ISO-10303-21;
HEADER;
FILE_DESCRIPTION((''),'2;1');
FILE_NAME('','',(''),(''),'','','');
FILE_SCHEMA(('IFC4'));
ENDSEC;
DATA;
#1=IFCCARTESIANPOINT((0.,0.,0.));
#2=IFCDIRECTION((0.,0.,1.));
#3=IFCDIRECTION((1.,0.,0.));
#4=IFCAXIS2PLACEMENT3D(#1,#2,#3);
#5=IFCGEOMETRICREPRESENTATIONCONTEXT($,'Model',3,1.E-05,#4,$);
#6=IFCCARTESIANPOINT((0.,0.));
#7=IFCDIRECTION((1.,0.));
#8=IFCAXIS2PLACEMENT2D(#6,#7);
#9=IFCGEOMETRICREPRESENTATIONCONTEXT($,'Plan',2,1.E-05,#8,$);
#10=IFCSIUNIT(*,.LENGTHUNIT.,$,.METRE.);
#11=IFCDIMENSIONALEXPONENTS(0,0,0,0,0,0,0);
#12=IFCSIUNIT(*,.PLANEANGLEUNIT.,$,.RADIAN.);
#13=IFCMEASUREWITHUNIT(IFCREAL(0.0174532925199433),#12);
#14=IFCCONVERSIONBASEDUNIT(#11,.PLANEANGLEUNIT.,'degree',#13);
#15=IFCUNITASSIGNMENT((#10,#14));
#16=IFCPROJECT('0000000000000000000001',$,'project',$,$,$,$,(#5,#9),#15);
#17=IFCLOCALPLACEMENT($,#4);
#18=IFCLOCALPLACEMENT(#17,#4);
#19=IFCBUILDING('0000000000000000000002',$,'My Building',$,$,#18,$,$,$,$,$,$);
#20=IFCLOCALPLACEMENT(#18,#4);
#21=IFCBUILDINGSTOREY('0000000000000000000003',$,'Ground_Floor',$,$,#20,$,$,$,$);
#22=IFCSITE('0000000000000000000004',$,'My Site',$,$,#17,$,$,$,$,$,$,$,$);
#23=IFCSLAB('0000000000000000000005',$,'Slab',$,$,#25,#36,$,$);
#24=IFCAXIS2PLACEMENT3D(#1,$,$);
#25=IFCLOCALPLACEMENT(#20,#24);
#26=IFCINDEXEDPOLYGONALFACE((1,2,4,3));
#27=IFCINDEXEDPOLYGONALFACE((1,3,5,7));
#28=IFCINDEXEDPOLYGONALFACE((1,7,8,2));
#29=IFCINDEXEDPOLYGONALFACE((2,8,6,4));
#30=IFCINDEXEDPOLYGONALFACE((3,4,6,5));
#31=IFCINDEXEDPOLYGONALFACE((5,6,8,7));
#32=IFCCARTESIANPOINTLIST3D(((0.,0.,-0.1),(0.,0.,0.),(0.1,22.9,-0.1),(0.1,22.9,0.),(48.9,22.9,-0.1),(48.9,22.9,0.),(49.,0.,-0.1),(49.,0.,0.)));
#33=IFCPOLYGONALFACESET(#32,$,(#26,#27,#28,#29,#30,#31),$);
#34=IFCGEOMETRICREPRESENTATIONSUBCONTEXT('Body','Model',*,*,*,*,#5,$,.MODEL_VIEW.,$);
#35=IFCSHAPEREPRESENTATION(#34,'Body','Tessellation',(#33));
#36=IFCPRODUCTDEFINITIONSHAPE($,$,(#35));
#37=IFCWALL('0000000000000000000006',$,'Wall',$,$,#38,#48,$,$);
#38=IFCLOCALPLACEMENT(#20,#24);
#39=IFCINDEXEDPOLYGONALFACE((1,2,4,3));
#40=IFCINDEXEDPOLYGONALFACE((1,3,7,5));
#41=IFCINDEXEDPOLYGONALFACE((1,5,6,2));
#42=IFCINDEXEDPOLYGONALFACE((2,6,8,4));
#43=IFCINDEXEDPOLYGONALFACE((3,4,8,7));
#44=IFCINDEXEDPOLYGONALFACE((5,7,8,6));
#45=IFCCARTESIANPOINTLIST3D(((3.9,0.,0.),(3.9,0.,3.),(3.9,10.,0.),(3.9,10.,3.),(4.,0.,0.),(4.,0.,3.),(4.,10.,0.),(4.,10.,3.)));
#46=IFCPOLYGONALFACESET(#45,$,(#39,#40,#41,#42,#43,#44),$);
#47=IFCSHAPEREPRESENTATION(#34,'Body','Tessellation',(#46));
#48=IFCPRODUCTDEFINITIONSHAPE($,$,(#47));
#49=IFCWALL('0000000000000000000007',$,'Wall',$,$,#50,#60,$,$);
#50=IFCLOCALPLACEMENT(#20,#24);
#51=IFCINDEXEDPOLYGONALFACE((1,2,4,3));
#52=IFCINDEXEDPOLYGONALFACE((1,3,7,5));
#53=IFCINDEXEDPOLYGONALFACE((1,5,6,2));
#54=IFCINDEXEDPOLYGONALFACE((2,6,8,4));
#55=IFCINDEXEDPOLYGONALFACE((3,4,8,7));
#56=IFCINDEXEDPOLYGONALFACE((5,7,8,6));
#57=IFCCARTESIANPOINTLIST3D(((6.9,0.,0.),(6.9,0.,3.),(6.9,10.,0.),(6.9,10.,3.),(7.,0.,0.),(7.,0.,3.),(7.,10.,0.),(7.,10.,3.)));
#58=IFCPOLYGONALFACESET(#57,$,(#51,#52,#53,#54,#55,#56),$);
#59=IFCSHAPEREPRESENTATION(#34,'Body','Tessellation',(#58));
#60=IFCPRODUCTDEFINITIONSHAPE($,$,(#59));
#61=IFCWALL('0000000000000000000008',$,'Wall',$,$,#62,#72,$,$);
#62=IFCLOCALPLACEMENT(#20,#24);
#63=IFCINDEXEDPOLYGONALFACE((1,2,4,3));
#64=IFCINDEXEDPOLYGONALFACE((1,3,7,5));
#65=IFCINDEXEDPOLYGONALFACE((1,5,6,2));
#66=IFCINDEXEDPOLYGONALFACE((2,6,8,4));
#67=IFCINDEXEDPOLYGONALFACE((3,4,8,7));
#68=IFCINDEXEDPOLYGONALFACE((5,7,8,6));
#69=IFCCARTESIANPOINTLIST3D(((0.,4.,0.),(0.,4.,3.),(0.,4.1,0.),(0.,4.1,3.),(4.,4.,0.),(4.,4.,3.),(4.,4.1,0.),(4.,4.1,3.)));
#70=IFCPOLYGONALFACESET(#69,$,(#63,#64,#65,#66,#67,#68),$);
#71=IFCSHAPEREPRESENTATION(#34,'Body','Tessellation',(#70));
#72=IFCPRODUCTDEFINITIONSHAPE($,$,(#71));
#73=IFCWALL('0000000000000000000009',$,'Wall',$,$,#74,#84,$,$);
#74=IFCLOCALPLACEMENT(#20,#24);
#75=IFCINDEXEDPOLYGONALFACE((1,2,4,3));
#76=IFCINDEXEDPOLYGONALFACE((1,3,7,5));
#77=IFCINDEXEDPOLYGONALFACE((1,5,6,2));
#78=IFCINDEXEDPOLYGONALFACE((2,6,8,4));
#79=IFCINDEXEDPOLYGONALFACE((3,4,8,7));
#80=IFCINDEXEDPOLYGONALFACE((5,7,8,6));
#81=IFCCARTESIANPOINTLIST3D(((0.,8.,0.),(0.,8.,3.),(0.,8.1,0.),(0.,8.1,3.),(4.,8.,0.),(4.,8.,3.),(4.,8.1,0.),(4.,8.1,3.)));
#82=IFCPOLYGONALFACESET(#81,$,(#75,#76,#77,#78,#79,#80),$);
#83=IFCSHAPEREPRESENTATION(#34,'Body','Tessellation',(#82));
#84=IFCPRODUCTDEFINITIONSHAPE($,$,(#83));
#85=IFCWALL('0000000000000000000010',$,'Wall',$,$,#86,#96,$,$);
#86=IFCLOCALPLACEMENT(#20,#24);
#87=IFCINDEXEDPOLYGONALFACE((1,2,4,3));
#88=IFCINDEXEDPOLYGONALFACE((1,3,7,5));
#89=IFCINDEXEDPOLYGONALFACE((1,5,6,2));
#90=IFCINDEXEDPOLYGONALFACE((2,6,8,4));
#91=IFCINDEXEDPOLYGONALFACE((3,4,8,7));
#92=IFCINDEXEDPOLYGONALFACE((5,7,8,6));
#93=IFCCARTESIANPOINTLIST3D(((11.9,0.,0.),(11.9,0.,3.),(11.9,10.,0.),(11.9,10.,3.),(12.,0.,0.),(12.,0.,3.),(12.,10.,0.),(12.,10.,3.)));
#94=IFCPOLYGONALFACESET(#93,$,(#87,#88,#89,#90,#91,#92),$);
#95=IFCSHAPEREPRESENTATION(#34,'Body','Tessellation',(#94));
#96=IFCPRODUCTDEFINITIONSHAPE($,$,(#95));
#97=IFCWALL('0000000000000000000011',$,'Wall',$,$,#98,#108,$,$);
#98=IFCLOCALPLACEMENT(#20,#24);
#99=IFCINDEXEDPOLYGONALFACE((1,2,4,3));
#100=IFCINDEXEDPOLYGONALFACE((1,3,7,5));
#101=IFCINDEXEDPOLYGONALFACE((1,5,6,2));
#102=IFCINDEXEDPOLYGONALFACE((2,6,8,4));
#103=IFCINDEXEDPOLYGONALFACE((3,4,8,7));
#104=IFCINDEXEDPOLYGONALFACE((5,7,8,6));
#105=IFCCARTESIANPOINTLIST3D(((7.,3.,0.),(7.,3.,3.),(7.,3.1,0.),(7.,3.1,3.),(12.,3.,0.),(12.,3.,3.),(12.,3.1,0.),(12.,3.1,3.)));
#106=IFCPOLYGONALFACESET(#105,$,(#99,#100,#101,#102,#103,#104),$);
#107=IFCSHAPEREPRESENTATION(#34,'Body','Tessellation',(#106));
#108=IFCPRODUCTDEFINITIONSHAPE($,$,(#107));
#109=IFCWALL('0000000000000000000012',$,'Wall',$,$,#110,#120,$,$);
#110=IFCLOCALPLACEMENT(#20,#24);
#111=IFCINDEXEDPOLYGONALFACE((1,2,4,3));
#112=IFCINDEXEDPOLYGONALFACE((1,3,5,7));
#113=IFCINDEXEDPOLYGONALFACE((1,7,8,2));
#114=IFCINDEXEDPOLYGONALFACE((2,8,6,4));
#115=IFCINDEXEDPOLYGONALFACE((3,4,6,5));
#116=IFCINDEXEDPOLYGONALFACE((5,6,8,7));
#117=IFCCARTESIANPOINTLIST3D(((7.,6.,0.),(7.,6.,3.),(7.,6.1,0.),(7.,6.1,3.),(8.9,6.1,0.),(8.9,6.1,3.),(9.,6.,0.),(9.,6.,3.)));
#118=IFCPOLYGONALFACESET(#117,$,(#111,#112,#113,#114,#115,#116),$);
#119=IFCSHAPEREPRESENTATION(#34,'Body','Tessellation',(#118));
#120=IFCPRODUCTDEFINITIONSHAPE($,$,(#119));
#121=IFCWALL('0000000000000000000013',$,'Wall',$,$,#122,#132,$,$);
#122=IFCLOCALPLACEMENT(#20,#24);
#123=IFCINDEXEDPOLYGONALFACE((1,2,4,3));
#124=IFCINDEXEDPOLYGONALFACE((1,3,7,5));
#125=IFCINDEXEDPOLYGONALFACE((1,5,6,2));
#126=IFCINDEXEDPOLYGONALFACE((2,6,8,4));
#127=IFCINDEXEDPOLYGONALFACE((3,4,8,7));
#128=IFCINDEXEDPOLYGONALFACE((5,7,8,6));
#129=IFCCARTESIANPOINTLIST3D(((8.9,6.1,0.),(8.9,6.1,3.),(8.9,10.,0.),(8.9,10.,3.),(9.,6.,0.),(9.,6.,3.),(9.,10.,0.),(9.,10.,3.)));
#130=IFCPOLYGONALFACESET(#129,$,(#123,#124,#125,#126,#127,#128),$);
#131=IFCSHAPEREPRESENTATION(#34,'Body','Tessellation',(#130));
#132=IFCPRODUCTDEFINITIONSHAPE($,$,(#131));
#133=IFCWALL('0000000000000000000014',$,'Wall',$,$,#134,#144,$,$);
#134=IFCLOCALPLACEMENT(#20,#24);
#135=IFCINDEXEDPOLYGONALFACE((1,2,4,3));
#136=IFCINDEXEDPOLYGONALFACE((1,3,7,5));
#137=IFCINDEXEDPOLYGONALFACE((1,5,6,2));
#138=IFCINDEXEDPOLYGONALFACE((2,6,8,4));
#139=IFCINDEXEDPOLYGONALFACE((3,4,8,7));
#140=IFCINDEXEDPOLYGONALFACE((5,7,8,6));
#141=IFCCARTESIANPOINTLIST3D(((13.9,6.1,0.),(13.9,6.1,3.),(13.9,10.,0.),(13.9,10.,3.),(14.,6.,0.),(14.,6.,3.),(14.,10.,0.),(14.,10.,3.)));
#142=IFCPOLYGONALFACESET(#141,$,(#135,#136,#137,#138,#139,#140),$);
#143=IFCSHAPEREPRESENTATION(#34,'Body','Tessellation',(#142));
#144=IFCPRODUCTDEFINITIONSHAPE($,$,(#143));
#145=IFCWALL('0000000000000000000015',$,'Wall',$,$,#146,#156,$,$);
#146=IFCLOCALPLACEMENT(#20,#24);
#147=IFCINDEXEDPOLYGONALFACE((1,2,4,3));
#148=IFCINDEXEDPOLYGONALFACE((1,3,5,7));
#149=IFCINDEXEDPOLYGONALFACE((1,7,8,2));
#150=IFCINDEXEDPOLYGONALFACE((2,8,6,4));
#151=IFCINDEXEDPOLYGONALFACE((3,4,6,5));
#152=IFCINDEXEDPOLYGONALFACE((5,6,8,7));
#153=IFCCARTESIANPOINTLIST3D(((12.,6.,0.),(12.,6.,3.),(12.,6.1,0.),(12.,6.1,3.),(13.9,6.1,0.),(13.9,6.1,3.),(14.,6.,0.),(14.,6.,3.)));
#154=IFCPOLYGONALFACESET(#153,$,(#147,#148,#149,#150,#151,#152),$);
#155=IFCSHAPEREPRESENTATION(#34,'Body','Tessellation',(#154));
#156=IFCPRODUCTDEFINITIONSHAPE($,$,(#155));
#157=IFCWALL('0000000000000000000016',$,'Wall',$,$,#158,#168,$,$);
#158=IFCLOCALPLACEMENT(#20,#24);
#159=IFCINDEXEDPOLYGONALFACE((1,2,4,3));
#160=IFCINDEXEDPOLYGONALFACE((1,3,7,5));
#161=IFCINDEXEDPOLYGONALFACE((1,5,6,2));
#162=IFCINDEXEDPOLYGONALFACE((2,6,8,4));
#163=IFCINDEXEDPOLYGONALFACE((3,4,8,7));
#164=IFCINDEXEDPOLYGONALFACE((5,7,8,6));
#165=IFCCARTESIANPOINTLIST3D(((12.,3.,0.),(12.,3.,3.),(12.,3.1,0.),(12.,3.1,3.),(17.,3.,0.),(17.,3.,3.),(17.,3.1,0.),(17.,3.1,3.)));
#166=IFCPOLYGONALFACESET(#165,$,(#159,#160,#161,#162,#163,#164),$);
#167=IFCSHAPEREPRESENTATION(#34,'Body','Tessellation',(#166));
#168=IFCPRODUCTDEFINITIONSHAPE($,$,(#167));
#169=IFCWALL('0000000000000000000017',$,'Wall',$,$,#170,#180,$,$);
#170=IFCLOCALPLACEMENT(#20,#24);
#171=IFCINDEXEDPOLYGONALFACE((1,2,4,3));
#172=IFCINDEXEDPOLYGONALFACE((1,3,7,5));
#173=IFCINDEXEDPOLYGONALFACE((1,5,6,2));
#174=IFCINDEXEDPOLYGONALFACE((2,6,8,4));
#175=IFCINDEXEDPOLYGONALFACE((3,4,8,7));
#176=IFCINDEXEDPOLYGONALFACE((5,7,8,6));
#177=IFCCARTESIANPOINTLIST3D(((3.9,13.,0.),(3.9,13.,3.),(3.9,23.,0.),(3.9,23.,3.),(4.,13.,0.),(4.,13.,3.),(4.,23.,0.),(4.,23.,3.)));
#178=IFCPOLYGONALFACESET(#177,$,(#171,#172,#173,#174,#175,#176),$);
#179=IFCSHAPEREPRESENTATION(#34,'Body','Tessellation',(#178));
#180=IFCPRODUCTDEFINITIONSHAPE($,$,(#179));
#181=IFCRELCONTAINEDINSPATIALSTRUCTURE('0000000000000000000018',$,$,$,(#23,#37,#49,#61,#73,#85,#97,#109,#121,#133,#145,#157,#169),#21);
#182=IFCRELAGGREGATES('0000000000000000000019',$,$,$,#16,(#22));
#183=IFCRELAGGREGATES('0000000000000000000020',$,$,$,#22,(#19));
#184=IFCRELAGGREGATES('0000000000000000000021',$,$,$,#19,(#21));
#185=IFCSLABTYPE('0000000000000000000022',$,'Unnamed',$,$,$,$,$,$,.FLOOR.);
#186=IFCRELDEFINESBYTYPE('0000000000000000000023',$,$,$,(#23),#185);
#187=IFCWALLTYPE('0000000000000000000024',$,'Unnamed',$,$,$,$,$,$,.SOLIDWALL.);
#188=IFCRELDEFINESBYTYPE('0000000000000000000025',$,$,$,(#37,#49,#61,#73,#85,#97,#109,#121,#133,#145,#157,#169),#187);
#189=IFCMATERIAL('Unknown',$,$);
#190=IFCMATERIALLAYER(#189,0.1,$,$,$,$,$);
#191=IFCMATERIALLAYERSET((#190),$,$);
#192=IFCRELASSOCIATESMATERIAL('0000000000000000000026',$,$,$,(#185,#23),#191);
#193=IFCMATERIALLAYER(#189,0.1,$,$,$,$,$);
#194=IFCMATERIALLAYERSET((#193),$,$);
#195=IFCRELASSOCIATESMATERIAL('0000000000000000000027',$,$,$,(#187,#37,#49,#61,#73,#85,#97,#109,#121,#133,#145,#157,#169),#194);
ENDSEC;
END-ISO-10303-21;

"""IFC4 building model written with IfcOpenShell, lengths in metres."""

from ifc_helpers import new_model, entity, si_unit, converted_unit, frame, origin_with_axes, origin_2d_with_axis, place, context, subcontext, project, spatial, line, indexed_curve, outline, extrude, material, layer, layer_set, layer_usage, type_object, element, save


model = new_model("IFC4")

# Units and contexts
model_context = context("Model", 3, precision=1e-05, world=origin_with_axes())
plan_context = context("Plan", 2, precision=1e-05, world=origin_2d_with_axis())
body_context = subcontext(model_context, "Body", "Model", "MODEL_VIEW")
ifc_project = project(units=[si_unit("LENGTHUNIT", "METRE"), converted_unit("PLANEANGLEUNIT", "degree", entity("IfcReal", 0.0174532925199433), si_unit("PLANEANGLEUNIT", "RADIAN"), dimensions=[0, 0, 0, 0, 0, 0, 0])], contexts=[model_context, plan_context])

# Site, building, storey
site_placement = place(None, origin_with_axes())
site = spatial("IfcSite", under=ifc_project, at=site_placement, Name="My Site")
building_placement = place(site_placement, origin_with_axes())
building = spatial("IfcBuilding", under=site, at=building_placement, Name="My Building")
storey_placement = place(building_placement, origin_with_axes())
storey = spatial("IfcBuildingStorey", under=building, at=storey_placement, Name="Ground_Floor")

# Slab
ifc_material = material(Name="Unknown")
ifc_layer_1 = layer(ifc_material, 0.1)
ifc_layer_set_1 = layer_set([ifc_layer_1])
ifc_layer_usage_1 = layer_usage(ifc_layer_set_1, "AXIS3", "POSITIVE", -0.1)
slab_type = type_object("IfcSlabType", Name="Unnamed", PredefinedType="FLOOR", material=ifc_layer_set_1)
slab_placement = place(storey_placement, frame((0.1, 22.9, 0.0), z_axis=(0.0, 0.0, 1.0), x_axis=(1.0, 0.0, 0.0)))
element("IfcSlab", 1, at=slab_placement, inside=storey, type_object=slab_type, material=ifc_layer_usage_1, Name="Slab", context=body_context, shape_type="SweptSolid", body=[
    extrude(outline(indexed_curve([(0.0, 0.0), (48.8, 0.0), (48.9, -22.9), (-0.1, -22.9), (0.0, 0.0)])), frame((0.0, 0.0, -0.1), z_axis=(0.0, 0.0, 1.0), x_axis=(1.0, 0.0, 0.0)), (0.0, 0.0, 1.0), 0.1),
])

# Walls
ifc_layer_2 = layer(ifc_material, 0.1)
ifc_layer_set_2 = layer_set([ifc_layer_2])
ifc_layer_usage_2 = layer_usage(ifc_layer_set_2, "AXIS2", "POSITIVE", 0.0)
wall_type = type_object("IfcWallType", Name="Unnamed", PredefinedType="SOLIDWALL", material=ifc_layer_set_2)
wall_1_placement = place(storey_placement, frame((4.0, 0.0, 0.0), z_axis=(0.0, 0.0, 1.0), x_axis=(0.0, 1.0, 0.0)))
element("IfcWall", 2, at=wall_1_placement, inside=storey, type_object=wall_type, material=ifc_layer_usage_2, Name="Wall", context=body_context, shape_type="SweptSolid", body=[
    extrude(outline(indexed_curve([(0.0, 0.0), (0.0, 0.1), (10.0, 0.1), (10.0, 0.0)], segments=[line(1, 2, 3, 4, 1)])), origin_with_axes(), (0.0, 0.0, 1.0), 3.0),
])
ifc_layer_usage_3 = layer_usage(ifc_layer_set_2, "AXIS2", "POSITIVE", 0.0)
wall_2_placement = place(storey_placement, frame((7.0, 0.0, 0.0), z_axis=(0.0, 0.0, 1.0), x_axis=(0.0, 1.0, 0.0)))
element("IfcWall", 3, at=wall_2_placement, inside=storey, type_object=wall_type, material=ifc_layer_usage_3, Name="Wall", context=body_context, shape_type="SweptSolid", body=[
    extrude(outline(indexed_curve([(0.0, 0.0), (0.0, 0.1), (10.0, 0.1), (10.0, 0.0)], segments=[line(1, 2, 3, 4, 1)])), origin_with_axes(), (0.0, 0.0, 1.0), 3.0),
])
ifc_layer_usage_4 = layer_usage(ifc_layer_set_2, "AXIS2", "POSITIVE", 0.0)
wall_3_placement = place(storey_placement, frame((0.0, 4.0, 0.0), z_axis=(0.0, 0.0, 1.0), x_axis=(1.0, 0.0, 0.0)))
element("IfcWall", 4, at=wall_3_placement, inside=storey, type_object=wall_type, material=ifc_layer_usage_4, Name="Wall", context=body_context, shape_type="SweptSolid", body=[
    extrude(outline(indexed_curve([(0.0, 0.0), (0.0, 0.1), (4.0, 0.1), (4.0, 0.0)], segments=[line(1, 2, 3, 4, 1)])), origin_with_axes(), (0.0, 0.0, 1.0), 3.0),
])
ifc_layer_usage_5 = layer_usage(ifc_layer_set_2, "AXIS2", "POSITIVE", 0.0)
wall_4_placement = place(storey_placement, frame((0.0, 8.0, 0.0), z_axis=(0.0, 0.0, 1.0), x_axis=(1.0, 0.0, 0.0)))
element("IfcWall", 5, at=wall_4_placement, inside=storey, type_object=wall_type, material=ifc_layer_usage_5, Name="Wall", context=body_context, shape_type="SweptSolid", body=[
    extrude(outline(indexed_curve([(0.0, 0.0), (0.0, 0.1), (4.0, 0.1), (4.0, 0.0)], segments=[line(1, 2, 3, 4, 1)])), origin_with_axes(), (0.0, 0.0, 1.0), 3.0),
])
ifc_layer_usage_6 = layer_usage(ifc_layer_set_2, "AXIS2", "POSITIVE", 0.0)
wall_5_placement = place(storey_placement, frame((12.0, 0.0, 0.0), z_axis=(0.0, 0.0, 1.0), x_axis=(0.0, 1.0, 0.0)))
element("IfcWall", 6, at=wall_5_placement, inside=storey, type_object=wall_type, material=ifc_layer_usage_6, Name="Wall", context=body_context, shape_type="SweptSolid", body=[
    extrude(outline(indexed_curve([(0.0, 0.0), (0.0, 0.1), (10.0, 0.1), (10.0, 0.0)], segments=[line(1, 2, 3, 4, 1)])), origin_with_axes(), (0.0, 0.0, 1.0), 3.0),
])
ifc_layer_usage_7 = layer_usage(ifc_layer_set_2, "AXIS2", "POSITIVE", 0.0)
wall_6_placement = place(storey_placement, frame((7.0, 3.0, 0.0), z_axis=(0.0, 0.0, 1.0), x_axis=(1.0, 0.0, 0.0)))
element("IfcWall", 7, at=wall_6_placement, inside=storey, type_object=wall_type, material=ifc_layer_usage_7, Name="Wall", context=body_context, shape_type="SweptSolid", body=[
    extrude(outline(indexed_curve([(0.0, 0.0), (0.0, 0.1), (5.0, 0.1), (5.0, 0.0)], segments=[line(1, 2, 3, 4, 1)])), origin_with_axes(), (0.0, 0.0, 1.0), 3.0),
])
ifc_layer_usage_8 = layer_usage(ifc_layer_set_2, "AXIS2", "POSITIVE", 0.0)
wall_7_placement = place(storey_placement, frame((7.0, 6.0, 0.0), z_axis=(0.0, 0.0, 1.0), x_axis=(1.0, 0.0, 0.0)))
element("IfcWall", 8, at=wall_7_placement, inside=storey, type_object=wall_type, material=ifc_layer_usage_8, Name="Wall", context=body_context, shape_type="SweptSolid", body=[
    extrude(outline(indexed_curve([(0.0, 0.0), (0.0, 0.1), (1.9, 0.1), (2.0, 0.0)], segments=[line(1, 2, 3, 4, 1)])), origin_with_axes(), (0.0, 0.0, 1.0), 3.0),
])
ifc_layer_usage_9 = layer_usage(ifc_layer_set_2, "AXIS2", "POSITIVE", 0.0)
wall_8_placement = place(storey_placement, frame((9.0, 6.0, 0.0), z_axis=(0.0, 0.0, 1.0), x_axis=(0.0, 1.0, 0.0)))
element("IfcWall", 9, at=wall_8_placement, inside=storey, type_object=wall_type, material=ifc_layer_usage_9, Name="Wall", context=body_context, shape_type="SweptSolid", body=[
    extrude(outline(indexed_curve([(0.0, 0.0), (0.1, 0.1), (4.0, 0.1), (4.0, 0.0)], segments=[line(1, 2, 3, 4, 1)])), origin_with_axes(), (0.0, 0.0, 1.0), 3.0),
])
ifc_layer_usage_10 = layer_usage(ifc_layer_set_2, "AXIS2", "POSITIVE", 0.0)
wall_9_placement = place(storey_placement, frame((14.0, 6.0, 0.0), z_axis=(0.0, 0.0, 1.0), x_axis=(0.0, 1.0, 0.0)))
element("IfcWall", 10, at=wall_9_placement, inside=storey, type_object=wall_type, material=ifc_layer_usage_10, Name="Wall", context=body_context, shape_type="SweptSolid", body=[
    extrude(outline(indexed_curve([(0.0, 0.0), (0.1, 0.1), (4.0, 0.1), (4.0, 0.0)], segments=[line(1, 2, 3, 4, 1)])), origin_with_axes(), (0.0, 0.0, 1.0), 3.0),
])
ifc_layer_usage_11 = layer_usage(ifc_layer_set_2, "AXIS2", "POSITIVE", 0.0)
wall_10_placement = place(storey_placement, frame((12.0, 6.0, 0.0), z_axis=(0.0, 0.0, 1.0), x_axis=(1.0, 0.0, 0.0)))
element("IfcWall", 11, at=wall_10_placement, inside=storey, type_object=wall_type, material=ifc_layer_usage_11, Name="Wall", context=body_context, shape_type="SweptSolid", body=[
    extrude(outline(indexed_curve([(0.0, 0.0), (0.0, 0.1), (1.9, 0.1), (2.0, 0.0)], segments=[line(1, 2, 3, 4, 1)])), origin_with_axes(), (0.0, 0.0, 1.0), 3.0),
])
ifc_layer_usage_12 = layer_usage(ifc_layer_set_2, "AXIS2", "POSITIVE", 0.0)
wall_11_placement = place(storey_placement, frame((12.0, 3.0, 0.0), z_axis=(0.0, 0.0, 1.0), x_axis=(1.0, 0.0, 0.0)))
element("IfcWall", 12, at=wall_11_placement, inside=storey, type_object=wall_type, material=ifc_layer_usage_12, Name="Wall", context=body_context, shape_type="SweptSolid", body=[
    extrude(outline(indexed_curve([(0.0, 0.0), (0.0, 0.1), (5.0, 0.1), (5.0, 0.0)], segments=[line(1, 2, 3, 4, 1)])), origin_with_axes(), (0.0, 0.0, 1.0), 3.0),
])
ifc_layer_usage_13 = layer_usage(ifc_layer_set_2, "AXIS2", "POSITIVE", 0.0)
wall_12_placement = place(storey_placement, frame((4.0, 13.0, 0.0), z_axis=(0.0, 0.0, 1.0), x_axis=(0.0, 1.0, 0.0)))
element("IfcWall", 13, at=wall_12_placement, inside=storey, type_object=wall_type, material=ifc_layer_usage_13, Name="Wall", context=body_context, shape_type="SweptSolid", body=[
    extrude(outline(indexed_curve([(0.0, 0.0), (0.0, 0.1), (10.0, 0.1), (10.0, 0.0)], segments=[line(1, 2, 3, 4, 1)])), origin_with_axes(), (0.0, 0.0, 1.0), 3.0),
])

save(model, "model.ifc")
